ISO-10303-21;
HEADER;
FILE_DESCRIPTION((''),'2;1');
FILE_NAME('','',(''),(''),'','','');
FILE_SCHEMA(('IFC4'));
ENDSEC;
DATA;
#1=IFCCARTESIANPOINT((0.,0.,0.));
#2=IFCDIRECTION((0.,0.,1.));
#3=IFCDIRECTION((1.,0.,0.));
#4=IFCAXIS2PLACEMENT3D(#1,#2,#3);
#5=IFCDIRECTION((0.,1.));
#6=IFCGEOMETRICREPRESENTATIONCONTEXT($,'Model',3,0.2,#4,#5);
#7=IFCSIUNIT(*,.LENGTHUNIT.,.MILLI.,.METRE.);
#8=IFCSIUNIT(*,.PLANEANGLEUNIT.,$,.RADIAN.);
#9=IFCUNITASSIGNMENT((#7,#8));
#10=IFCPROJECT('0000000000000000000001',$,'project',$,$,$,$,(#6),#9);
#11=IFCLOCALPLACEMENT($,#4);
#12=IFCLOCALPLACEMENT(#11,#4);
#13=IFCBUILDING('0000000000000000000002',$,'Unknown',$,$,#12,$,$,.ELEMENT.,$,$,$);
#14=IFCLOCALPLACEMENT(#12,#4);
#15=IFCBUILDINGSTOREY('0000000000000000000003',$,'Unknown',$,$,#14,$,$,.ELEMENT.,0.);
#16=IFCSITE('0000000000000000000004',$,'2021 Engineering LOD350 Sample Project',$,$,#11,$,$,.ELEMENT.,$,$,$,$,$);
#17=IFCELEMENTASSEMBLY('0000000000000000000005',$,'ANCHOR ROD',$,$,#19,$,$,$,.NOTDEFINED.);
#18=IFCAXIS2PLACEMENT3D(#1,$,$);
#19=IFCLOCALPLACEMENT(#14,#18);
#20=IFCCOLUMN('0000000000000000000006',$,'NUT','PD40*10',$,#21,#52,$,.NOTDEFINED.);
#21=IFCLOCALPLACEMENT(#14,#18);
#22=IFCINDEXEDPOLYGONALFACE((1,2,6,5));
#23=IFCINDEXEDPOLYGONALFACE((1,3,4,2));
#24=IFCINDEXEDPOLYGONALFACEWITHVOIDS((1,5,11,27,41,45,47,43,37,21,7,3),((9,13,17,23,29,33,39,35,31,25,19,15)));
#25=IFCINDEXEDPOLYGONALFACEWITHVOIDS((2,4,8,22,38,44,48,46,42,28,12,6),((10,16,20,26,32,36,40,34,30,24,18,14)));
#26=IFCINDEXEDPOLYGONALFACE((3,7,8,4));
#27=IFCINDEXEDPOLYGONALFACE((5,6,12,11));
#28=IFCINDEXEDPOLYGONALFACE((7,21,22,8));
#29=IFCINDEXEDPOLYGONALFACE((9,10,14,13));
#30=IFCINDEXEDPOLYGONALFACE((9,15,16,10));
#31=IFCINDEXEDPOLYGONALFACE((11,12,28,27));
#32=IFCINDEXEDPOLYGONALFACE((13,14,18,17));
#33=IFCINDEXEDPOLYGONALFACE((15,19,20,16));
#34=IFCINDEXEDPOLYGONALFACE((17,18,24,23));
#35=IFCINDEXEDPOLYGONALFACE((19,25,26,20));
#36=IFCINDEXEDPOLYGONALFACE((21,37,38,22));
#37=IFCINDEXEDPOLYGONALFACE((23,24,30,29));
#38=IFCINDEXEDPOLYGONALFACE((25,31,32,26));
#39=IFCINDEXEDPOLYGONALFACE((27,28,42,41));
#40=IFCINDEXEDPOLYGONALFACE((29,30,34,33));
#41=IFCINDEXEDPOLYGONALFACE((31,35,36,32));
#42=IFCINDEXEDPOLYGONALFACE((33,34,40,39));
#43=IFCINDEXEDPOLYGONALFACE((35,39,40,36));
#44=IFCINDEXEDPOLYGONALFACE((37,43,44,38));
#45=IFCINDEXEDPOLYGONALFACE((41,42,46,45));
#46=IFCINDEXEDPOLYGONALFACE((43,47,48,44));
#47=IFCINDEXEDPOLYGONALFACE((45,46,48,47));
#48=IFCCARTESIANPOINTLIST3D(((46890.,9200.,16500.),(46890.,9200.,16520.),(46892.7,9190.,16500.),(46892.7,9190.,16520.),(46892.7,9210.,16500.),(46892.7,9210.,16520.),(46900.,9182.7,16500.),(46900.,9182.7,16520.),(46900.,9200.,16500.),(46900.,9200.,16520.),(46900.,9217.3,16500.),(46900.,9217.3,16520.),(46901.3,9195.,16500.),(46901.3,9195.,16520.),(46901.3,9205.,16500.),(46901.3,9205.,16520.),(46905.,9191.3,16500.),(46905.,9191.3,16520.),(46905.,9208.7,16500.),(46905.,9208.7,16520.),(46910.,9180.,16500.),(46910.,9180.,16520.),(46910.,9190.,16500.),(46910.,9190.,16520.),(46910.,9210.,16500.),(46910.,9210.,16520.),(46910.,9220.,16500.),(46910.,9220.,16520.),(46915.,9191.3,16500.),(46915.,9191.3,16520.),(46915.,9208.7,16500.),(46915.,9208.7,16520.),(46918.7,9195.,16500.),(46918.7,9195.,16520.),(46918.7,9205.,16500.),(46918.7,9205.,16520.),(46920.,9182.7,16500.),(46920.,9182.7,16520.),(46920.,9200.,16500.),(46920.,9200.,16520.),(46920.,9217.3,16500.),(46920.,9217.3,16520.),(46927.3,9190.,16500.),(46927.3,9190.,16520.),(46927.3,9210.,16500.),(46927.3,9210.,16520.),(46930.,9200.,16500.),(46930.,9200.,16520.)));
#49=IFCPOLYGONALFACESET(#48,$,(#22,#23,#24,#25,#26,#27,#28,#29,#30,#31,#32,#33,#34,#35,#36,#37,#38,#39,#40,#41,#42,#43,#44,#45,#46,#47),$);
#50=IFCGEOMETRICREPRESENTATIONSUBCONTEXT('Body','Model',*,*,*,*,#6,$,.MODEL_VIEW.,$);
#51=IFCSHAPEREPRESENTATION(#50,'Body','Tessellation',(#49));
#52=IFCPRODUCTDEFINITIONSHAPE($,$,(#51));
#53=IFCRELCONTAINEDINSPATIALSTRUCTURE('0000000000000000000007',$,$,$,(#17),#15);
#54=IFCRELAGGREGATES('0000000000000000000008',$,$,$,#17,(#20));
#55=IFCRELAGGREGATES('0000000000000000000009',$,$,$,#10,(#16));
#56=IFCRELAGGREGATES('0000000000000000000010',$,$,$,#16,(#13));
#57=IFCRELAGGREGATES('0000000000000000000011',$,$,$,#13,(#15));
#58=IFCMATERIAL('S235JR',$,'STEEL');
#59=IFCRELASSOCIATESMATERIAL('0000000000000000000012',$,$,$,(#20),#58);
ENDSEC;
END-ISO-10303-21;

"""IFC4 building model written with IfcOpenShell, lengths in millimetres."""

from ifc_helpers import new_model, si_unit, direction, frame, origin_with_axes, place, context, subcontext, project, spatial, line, indexed_curve, outline, extrude, material, element, aggregate, save


model = new_model("IFC4")

# Units and contexts
model_context = context("Model", 3, precision=0.2, world=origin_with_axes(), true_north=direction((0.0, 1.0)))
body_context = subcontext(model_context, "Body", "Model", "MODEL_VIEW")
ifc_project = project(units=[si_unit("LENGTHUNIT", "METRE", prefix="MILLI"), si_unit("PLANEANGLEUNIT", "RADIAN")], contexts=[model_context])

# Site, building, storey
site_placement = place(None, origin_with_axes())
site = spatial("IfcSite", under=ifc_project, at=site_placement, Name="2021 Engineering LOD350 Sample Project", CompositionType="ELEMENT")
building_placement = place(site_placement, origin_with_axes())
building = spatial("IfcBuilding", under=site, at=building_placement, Name="Unknown", CompositionType="ELEMENT")
storey_placement = place(building_placement, origin_with_axes())
storey = spatial("IfcBuildingStorey", under=building, at=storey_placement, Name="Unknown", CompositionType="ELEMENT", Elevation=0.0)

# Element assembly, column
assembly_1_placement = place(storey_placement, frame((47290.0, 9400.0, 16730.0), z_axis=(1.0, 0.0, 0.0), x_axis=(0.0, 0.0, -1.0)))
assembly_1 = element("IfcElementAssembly", 1, at=assembly_1_placement, inside=storey, Name="ANCHOR ROD", PredefinedType="NOTDEFINED")
ifc_material_1 = material(Name="S235JR", Category="STEEL")
column_placement = place(assembly_1_placement, frame((210.0, -200.0, -380.0), z_axis=(0.0, 0.0, -1.0), x_axis=(1.0, 0.0, 0.0)))
column = element("IfcColumn", 2, at=column_placement, material=ifc_material_1, Name="NUT", Description="PD40*10", PredefinedType="NOTDEFINED", context=body_context, shape_type="SolidModel", body=[
    extrude(outline(indexed_curve([(20.0, 0.0), (17.3, 10.0), (10.0, 17.3), (0.0, 20.0), (-10.0, 17.3), (-17.3, 10.0), (-20.0, 0.0), (-17.3, -10.0), (-10.0, -17.3), (0.0, -20.0), (10.0, -17.3), (17.3, -10.0)], segments=[line(1, 2, 3, 4, 5, 6, 7, 8, 9, 10, 11, 12, 1)]), holes=[indexed_curve([(10.0, 0.0), (8.7, -5.0), (5.0, -8.7), (0.0, -10.0), (-5.0, -8.7), (-8.7, -5.0), (-10.0, 0.0), (-8.7, 5.0), (-5.0, 8.7), (0.0, 10.0), (5.0, 8.7), (8.7, 5.0)], segments=[line(1, 2, 3, 4, 5, 6, 7, 8, 9, 10, 11, 12, 1)])]), frame((0.0, 0.0, 0.0), z_axis=(-1.0, 0.0, 0.0), x_axis=(0.0, 0.0, 1.0)), (0.0, 0.0, -1.0), 20.0),
])

aggregate(assembly_1, [column])

save(model, "model.ifc")
